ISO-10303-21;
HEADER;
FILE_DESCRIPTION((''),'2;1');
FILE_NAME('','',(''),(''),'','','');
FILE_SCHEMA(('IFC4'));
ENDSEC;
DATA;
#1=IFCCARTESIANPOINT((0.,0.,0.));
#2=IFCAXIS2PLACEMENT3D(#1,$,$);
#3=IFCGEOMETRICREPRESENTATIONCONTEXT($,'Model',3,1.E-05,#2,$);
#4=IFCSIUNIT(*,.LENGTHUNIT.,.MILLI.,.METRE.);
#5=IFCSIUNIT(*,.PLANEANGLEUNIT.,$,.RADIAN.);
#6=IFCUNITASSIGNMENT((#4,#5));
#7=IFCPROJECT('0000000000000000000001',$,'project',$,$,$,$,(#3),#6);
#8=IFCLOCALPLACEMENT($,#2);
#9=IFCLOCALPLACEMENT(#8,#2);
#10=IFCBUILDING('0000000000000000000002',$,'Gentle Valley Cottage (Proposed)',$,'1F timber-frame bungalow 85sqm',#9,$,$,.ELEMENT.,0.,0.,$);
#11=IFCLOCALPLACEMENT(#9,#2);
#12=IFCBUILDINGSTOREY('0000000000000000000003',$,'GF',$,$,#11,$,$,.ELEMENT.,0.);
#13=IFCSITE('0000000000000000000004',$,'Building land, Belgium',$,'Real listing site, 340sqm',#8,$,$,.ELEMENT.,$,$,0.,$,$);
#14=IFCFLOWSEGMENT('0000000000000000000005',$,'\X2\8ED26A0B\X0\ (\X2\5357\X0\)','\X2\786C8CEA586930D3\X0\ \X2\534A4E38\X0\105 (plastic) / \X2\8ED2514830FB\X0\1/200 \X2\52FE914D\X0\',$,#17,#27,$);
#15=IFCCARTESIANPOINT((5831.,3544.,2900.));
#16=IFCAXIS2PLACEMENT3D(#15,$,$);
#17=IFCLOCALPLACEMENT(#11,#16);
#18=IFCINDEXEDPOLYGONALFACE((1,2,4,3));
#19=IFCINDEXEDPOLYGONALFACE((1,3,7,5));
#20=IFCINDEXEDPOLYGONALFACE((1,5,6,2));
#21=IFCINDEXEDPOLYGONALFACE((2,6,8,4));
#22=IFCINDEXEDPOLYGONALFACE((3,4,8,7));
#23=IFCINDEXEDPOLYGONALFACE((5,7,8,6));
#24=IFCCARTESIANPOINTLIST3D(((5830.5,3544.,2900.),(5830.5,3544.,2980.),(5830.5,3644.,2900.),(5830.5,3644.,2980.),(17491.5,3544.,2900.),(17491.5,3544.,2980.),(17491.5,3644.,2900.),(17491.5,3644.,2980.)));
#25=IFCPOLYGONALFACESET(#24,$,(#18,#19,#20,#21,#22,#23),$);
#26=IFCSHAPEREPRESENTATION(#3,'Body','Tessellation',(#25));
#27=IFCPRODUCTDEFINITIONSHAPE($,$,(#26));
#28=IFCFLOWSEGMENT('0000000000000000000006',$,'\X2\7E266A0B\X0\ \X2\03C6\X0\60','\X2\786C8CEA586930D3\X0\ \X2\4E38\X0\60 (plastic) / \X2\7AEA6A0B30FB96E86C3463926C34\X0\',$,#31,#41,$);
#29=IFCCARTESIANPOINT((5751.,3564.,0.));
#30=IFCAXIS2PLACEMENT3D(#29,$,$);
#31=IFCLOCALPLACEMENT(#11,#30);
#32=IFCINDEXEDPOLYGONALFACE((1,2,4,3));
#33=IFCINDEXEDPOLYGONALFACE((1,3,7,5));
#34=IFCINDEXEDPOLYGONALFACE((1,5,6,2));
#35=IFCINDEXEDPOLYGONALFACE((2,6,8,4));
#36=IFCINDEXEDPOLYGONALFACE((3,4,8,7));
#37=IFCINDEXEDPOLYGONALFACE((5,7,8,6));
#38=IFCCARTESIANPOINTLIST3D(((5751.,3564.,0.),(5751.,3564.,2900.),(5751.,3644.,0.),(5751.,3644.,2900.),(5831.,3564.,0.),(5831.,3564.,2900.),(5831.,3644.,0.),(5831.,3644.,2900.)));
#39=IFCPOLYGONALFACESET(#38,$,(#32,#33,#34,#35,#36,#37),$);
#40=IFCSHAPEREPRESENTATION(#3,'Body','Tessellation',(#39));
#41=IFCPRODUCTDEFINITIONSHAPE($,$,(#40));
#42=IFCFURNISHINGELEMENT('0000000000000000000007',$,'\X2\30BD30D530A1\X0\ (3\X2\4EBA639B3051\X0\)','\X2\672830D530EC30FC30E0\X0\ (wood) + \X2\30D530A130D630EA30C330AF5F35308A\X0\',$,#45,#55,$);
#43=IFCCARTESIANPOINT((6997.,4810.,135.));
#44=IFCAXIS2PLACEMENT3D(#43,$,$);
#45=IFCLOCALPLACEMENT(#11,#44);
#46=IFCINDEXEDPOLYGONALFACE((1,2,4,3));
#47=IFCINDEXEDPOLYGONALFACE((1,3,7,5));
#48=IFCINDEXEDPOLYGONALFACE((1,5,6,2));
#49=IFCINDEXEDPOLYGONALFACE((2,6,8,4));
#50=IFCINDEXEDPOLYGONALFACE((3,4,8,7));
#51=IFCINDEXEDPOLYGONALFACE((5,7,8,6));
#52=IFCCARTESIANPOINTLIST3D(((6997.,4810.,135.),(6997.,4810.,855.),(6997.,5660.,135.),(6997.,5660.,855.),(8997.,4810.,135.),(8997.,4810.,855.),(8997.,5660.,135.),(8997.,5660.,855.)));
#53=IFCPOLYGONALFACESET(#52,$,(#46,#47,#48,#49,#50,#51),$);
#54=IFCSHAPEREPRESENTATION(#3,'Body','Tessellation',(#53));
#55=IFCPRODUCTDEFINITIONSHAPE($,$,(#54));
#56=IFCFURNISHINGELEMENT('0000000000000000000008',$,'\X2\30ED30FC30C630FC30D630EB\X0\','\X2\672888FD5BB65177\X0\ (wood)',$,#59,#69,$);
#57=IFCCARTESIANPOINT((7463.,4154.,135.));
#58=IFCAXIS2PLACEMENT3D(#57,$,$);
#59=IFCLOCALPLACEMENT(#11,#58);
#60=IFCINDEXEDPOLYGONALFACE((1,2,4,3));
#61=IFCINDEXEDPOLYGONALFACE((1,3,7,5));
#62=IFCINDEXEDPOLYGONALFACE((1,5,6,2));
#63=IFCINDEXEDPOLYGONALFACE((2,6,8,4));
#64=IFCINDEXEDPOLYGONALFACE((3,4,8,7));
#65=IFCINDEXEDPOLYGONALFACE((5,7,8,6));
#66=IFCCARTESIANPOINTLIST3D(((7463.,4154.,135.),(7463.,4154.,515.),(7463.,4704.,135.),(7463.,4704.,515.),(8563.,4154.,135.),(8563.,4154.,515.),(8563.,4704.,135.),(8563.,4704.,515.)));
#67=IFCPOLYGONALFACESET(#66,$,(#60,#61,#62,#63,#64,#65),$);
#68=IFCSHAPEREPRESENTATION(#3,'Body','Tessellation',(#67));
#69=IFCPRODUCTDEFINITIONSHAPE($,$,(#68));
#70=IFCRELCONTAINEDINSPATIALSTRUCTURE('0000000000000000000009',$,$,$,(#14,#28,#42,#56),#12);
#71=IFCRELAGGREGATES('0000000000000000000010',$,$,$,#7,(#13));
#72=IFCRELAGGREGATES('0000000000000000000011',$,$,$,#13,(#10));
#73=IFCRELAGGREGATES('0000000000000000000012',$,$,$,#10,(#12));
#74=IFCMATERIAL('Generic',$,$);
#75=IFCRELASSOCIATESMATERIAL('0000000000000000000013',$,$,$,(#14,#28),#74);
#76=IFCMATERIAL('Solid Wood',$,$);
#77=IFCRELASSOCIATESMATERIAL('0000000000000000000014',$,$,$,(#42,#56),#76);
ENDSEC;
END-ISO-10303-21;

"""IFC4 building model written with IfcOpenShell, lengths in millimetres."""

from ifc_helpers import new_model, si_unit, frame, frame_2d, origin, place, context, project, spatial, rectangle, extrude, material, element, save


model = new_model("IFC4")

# Units and contexts
model_context = context("Model", 3, precision=1e-05, world=origin())
ifc_project = project(units=[si_unit("LENGTHUNIT", "METRE", prefix="MILLI"), si_unit("PLANEANGLEUNIT", "RADIAN")], contexts=[model_context])

# Site, building, storey
site_placement = place(None, origin())
site = spatial("IfcSite", under=ifc_project, at=site_placement, Name="Building land, Belgium", ObjectType="Real listing site, 340sqm", CompositionType="ELEMENT", RefElevation=0.0)
building_placement = place(site_placement, origin())
building = spatial("IfcBuilding", under=site, at=building_placement, Name="Gentle Valley Cottage (Proposed)", ObjectType="1F timber-frame bungalow 85sqm", CompositionType="ELEMENT", ElevationOfRefHeight=0.0, ElevationOfTerrain=0.0)
storey_placement = place(building_placement, origin())
storey = spatial("IfcBuildingStorey", under=building, at=storey_placement, Name="GF", CompositionType="ELEMENT", Elevation=0.0)

# Shared definitions
ifc_material_1 = material(Name="Solid Wood")

# Shared definitions
ifc_material_2 = material(Name="Generic")

# Flow segments
flow_segment_1_placement = place(storey_placement, frame((5831.0, 3544.0, 2900.0)))
element("IfcFlowSegment", 1, at=flow_segment_1_placement, inside=storey, material=ifc_material_2, Name="軒樋 (南)", Description="硬質塩ビ 半丸105 (plastic) / 軒先・1/200 勾配", context=model_context, shape_type="SweptSolid", body=[
    extrude(rectangle(XDim=11661.0, YDim=100.0, at=frame_2d((5830.0, 50.0))), frame((5831.0, 3544.0, 2900.0)), (0.0, 0.0, 1.0), 80.0),
])
flow_segment_2_placement = place(storey_placement, frame((5751.0, 3564.0, 0.0)))
element("IfcFlowSegment", 2, at=flow_segment_2_placement, inside=storey, material=ifc_material_2, Name="縦樋 φ60", Description="硬質塩ビ 丸60 (plastic) / 竪樋・雨水排水", context=model_context, shape_type="SweptSolid", body=[
    extrude(rectangle(XDim=80.0, YDim=80.0, at=frame_2d((40.0, 40.0))), frame((5751.0, 3564.0, 0.0)), (0.0, 0.0, 1.0), 2900.0),
])

# Furnishing elements
furnishing_1_placement = place(storey_placement, frame((6997.0, 4810.0, 135.0)))
element("IfcFurnishingElement", 3, at=furnishing_1_placement, inside=storey, material=ifc_material_1, Name="ソファ (3人掛け)", Description="木フレーム (wood) + ファブリック張り", context=model_context, shape_type="SweptSolid", body=[
    extrude(rectangle(XDim=2000.0, YDim=850.0, at=frame_2d((1000.0, 425.0))), frame((6997.0, 4810.0, 135.0)), (0.0, 0.0, 1.0), 720.0),
])
furnishing_2_placement = place(storey_placement, frame((7463.0, 4154.0, 135.0)))
element("IfcFurnishingElement", 4, at=furnishing_2_placement, inside=storey, material=ifc_material_1, Name="ローテーブル", Description="木製家具 (wood)", context=model_context, shape_type="SweptSolid", body=[
    extrude(rectangle(XDim=1100.0, YDim=550.0, at=frame_2d((550.0, 275.0))), frame((7463.0, 4154.0, 135.0)), (0.0, 0.0, 1.0), 380.0),
])

save(model, "model.ifc")
